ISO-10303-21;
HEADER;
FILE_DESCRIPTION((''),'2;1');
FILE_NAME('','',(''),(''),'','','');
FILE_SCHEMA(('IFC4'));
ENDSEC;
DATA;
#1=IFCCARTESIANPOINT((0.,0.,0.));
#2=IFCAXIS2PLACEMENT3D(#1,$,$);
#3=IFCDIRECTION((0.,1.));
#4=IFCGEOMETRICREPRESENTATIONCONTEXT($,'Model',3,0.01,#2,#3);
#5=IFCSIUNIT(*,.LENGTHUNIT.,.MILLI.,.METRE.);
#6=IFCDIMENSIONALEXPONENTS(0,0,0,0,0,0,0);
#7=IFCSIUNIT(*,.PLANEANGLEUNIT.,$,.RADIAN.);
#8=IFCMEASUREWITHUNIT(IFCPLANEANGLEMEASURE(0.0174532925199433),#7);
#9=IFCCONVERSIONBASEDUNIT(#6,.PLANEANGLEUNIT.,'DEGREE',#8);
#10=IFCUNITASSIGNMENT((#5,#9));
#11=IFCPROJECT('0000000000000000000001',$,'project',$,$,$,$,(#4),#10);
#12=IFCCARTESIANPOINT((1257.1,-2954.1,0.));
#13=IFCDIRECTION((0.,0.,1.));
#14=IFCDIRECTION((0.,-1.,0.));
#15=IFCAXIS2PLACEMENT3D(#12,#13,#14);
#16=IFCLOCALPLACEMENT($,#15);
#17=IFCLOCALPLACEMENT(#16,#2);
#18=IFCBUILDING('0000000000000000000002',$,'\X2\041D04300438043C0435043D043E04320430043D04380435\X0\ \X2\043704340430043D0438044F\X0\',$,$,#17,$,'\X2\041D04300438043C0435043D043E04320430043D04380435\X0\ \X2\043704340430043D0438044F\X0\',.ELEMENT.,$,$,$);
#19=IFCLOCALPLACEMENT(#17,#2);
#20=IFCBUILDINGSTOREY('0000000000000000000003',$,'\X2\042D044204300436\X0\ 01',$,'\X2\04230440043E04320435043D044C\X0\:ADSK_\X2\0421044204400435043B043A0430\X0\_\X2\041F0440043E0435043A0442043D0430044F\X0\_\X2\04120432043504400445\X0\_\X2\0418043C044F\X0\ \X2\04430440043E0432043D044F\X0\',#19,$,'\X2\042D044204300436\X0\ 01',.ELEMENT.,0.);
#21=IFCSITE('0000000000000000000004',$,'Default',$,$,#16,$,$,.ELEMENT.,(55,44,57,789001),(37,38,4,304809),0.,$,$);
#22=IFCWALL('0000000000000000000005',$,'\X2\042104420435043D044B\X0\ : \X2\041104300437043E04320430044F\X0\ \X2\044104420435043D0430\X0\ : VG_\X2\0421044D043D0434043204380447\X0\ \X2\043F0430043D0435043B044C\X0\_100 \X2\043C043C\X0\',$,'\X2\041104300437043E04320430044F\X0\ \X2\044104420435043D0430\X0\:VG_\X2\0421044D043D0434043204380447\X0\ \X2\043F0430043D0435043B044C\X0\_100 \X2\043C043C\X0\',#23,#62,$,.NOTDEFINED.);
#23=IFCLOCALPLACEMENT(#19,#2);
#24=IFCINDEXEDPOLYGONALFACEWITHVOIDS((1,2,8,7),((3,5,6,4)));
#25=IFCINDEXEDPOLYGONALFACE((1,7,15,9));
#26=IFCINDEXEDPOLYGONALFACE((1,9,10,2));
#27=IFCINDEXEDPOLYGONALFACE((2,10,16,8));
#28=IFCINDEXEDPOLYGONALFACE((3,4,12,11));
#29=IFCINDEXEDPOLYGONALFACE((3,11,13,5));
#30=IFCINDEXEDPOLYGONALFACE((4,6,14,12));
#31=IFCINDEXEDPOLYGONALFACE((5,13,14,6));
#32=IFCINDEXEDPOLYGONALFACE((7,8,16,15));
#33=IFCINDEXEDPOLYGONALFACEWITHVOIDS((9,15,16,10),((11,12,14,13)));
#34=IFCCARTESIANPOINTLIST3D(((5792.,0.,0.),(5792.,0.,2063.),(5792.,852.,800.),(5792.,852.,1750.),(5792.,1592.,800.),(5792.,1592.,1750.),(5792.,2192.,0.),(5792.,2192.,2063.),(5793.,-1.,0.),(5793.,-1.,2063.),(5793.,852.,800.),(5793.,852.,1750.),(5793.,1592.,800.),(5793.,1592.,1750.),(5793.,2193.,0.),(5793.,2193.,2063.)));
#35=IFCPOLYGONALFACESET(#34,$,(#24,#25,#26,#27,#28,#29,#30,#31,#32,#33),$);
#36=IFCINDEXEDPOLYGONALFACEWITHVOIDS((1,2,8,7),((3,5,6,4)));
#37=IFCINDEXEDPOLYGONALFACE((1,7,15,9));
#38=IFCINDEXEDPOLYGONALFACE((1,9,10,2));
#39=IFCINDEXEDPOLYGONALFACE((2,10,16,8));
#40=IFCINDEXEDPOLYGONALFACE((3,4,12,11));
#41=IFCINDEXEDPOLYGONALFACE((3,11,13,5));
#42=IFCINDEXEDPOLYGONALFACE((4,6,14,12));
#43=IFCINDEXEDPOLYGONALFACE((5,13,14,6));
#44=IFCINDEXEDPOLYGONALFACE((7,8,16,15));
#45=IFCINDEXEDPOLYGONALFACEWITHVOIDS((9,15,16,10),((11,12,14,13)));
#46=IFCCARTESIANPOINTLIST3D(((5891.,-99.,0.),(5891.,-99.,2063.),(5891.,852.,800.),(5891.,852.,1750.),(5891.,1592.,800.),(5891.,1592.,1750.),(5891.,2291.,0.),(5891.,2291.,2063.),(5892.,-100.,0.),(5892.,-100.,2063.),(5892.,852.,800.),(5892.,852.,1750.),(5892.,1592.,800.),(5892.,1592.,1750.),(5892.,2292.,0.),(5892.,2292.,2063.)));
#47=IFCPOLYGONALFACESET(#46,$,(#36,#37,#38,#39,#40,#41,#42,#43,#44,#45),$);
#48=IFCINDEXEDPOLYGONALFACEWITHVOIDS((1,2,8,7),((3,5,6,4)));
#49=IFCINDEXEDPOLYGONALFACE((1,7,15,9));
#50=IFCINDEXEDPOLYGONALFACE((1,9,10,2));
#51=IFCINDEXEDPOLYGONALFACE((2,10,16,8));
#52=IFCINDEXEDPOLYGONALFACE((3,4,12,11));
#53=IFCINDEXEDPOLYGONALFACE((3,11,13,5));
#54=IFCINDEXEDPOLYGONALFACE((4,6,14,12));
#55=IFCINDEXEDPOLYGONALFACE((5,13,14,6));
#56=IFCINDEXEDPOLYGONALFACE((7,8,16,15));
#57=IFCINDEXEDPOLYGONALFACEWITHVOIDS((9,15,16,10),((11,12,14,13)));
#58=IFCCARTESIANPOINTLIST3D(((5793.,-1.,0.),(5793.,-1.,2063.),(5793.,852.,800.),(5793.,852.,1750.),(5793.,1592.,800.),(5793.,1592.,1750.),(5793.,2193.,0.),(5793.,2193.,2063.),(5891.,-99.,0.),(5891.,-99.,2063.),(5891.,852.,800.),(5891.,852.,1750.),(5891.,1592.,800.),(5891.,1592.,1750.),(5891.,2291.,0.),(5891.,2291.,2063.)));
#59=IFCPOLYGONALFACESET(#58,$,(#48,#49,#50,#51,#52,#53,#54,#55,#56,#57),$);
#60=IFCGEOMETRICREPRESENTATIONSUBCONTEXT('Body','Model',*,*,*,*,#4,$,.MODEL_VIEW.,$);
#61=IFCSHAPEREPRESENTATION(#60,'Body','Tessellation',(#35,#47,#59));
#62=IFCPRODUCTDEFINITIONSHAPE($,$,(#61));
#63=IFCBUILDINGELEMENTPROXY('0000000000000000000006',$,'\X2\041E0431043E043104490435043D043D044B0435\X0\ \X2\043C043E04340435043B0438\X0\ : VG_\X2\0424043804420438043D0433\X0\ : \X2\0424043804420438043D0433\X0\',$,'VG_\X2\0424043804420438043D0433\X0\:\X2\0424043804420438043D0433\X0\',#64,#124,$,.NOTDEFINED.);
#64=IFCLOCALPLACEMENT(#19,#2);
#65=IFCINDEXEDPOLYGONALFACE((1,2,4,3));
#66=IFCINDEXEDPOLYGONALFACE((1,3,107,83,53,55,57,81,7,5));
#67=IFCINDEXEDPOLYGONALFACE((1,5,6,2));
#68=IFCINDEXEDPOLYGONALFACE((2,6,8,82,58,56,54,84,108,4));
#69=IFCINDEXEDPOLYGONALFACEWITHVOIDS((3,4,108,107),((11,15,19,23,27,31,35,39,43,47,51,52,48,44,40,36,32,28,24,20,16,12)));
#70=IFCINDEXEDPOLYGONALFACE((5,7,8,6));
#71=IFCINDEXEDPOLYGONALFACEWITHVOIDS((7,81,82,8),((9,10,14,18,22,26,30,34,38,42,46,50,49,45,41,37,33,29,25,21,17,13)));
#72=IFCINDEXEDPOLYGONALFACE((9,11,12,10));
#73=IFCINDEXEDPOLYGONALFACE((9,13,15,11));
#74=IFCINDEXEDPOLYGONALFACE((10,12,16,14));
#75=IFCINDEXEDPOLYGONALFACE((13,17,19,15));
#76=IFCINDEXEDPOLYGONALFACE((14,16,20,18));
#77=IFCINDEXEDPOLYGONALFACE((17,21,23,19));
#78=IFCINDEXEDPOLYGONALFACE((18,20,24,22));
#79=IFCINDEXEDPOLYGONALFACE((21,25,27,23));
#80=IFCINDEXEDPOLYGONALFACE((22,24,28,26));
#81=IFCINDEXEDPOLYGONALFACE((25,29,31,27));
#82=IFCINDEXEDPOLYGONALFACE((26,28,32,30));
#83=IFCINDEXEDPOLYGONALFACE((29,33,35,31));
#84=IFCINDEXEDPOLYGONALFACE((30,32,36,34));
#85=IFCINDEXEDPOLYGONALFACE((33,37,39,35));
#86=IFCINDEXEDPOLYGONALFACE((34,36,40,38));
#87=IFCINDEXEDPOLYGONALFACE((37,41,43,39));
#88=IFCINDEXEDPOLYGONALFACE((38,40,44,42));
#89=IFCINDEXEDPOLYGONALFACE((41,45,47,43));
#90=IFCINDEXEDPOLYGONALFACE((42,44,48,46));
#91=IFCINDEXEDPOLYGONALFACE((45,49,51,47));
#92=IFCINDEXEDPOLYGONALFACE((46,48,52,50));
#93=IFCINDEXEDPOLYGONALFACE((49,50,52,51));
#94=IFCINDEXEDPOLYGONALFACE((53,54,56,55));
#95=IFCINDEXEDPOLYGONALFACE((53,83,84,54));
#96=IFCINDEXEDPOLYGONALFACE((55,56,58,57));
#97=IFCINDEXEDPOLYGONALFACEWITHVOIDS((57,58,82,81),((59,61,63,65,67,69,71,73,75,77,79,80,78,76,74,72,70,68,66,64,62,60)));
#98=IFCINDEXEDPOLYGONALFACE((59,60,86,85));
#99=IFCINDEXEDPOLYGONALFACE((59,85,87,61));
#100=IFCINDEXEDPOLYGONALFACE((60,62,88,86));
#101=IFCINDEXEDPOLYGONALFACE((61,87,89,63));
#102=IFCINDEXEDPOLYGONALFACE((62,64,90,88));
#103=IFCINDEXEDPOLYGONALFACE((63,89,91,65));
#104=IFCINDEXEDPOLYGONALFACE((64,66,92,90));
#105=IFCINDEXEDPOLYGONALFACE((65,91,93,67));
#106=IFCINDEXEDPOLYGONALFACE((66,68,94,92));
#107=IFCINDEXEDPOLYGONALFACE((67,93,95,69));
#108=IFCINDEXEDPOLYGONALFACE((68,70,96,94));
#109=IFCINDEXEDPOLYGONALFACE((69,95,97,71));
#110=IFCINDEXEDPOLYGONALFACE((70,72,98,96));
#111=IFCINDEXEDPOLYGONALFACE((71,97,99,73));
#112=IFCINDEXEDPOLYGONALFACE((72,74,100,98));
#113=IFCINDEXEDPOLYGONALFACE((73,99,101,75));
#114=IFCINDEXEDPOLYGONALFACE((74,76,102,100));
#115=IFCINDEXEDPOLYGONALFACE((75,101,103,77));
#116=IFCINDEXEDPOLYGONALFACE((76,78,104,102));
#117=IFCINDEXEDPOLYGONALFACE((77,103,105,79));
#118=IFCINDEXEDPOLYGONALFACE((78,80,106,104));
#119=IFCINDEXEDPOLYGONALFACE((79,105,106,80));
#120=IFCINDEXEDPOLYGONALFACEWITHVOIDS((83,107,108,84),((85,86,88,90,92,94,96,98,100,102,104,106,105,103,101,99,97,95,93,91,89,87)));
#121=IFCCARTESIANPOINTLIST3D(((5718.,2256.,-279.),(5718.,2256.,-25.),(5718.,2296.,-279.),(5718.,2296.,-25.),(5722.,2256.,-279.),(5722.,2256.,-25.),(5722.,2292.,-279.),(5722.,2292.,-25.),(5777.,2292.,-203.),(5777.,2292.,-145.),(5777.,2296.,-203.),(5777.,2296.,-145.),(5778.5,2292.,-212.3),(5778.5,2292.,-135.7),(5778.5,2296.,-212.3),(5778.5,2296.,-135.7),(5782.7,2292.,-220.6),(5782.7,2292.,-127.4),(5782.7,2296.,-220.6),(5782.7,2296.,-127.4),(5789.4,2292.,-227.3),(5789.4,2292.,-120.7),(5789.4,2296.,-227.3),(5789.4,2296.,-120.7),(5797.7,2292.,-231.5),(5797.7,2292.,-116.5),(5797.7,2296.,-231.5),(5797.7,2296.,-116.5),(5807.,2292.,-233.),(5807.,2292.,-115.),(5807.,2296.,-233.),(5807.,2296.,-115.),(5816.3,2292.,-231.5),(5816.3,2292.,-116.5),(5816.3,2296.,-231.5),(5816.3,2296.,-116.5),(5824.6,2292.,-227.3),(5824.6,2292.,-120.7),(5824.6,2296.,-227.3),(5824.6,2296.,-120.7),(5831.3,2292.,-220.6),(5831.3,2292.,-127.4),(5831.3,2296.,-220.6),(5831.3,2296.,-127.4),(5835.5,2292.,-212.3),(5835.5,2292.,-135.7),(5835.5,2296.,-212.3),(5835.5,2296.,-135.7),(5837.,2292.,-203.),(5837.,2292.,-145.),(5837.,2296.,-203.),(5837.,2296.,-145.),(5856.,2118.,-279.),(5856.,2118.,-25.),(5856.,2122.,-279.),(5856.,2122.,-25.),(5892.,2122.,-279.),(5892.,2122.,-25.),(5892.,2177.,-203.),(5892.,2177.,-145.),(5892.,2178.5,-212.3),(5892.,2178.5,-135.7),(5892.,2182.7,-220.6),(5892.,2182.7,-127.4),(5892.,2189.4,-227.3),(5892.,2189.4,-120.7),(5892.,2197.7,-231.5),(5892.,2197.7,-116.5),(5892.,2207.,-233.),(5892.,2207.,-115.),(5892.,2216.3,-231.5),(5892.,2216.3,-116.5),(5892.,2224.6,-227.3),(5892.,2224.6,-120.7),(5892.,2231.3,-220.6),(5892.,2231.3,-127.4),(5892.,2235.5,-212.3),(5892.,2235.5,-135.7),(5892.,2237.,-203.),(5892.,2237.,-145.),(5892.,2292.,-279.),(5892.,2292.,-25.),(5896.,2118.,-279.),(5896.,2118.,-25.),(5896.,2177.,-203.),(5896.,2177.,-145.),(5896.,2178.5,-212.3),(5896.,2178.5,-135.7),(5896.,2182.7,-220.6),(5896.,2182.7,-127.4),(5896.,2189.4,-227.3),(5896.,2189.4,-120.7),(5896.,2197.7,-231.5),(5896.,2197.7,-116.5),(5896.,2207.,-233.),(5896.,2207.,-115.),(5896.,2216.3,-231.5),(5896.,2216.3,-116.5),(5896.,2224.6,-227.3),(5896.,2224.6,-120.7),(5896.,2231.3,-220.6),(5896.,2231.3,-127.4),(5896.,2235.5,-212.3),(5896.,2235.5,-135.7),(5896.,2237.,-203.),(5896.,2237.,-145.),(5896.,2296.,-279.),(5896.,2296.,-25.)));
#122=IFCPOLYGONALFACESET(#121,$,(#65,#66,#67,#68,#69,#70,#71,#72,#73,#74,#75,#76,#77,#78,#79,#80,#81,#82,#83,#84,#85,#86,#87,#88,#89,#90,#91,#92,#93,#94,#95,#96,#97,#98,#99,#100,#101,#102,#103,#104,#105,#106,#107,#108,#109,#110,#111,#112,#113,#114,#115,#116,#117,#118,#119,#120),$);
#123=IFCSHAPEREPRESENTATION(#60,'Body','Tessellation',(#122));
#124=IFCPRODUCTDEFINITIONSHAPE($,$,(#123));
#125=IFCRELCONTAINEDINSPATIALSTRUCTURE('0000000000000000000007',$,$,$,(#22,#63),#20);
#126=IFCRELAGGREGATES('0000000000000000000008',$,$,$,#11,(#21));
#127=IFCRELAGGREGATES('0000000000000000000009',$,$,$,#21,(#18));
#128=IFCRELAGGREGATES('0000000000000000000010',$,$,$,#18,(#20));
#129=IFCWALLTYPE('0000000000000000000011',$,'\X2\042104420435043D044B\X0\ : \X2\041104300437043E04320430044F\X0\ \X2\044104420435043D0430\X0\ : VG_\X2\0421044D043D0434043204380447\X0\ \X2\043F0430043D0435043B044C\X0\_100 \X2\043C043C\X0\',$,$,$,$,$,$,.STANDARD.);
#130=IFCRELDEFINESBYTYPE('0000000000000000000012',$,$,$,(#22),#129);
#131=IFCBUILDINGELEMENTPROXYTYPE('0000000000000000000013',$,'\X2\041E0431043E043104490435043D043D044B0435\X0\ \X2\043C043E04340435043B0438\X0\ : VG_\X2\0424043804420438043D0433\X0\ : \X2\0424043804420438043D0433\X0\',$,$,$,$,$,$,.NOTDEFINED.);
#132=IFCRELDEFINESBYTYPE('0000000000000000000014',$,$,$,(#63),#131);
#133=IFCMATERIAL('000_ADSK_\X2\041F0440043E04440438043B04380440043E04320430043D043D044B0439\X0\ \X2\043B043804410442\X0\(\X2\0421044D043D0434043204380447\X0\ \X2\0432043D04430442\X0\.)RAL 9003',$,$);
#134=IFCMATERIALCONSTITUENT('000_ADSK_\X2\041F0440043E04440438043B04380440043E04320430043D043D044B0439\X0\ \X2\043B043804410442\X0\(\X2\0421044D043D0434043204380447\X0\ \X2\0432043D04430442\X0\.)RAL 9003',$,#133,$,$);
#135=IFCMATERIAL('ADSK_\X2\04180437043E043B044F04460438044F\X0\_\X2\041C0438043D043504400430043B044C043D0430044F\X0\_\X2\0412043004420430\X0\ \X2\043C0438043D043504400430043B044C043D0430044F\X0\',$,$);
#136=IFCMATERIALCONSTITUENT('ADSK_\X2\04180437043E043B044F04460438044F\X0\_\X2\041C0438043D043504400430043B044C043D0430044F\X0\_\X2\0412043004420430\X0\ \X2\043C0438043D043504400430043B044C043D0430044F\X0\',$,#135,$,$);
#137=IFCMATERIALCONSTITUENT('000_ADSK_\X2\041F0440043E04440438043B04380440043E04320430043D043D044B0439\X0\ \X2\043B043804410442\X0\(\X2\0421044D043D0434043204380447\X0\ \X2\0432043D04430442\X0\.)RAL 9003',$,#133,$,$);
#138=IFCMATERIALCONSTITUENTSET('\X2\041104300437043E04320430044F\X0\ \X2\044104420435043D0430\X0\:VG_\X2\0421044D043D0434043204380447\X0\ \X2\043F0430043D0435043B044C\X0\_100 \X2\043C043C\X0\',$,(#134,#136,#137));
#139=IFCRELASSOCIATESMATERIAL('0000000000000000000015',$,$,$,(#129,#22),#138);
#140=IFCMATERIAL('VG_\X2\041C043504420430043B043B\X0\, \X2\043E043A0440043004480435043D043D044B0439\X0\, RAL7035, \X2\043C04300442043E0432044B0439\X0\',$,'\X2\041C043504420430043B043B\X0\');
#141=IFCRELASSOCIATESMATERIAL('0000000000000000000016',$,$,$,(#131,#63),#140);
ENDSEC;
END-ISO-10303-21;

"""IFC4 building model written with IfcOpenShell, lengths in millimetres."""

from ifc_helpers import new_model, entity, si_unit, converted_unit, direction, frame, origin, place, context, subcontext, project, spatial, indexed_curve, outline, extrude, source, transform, mapped, material, constituent, constituent_set, type_object, type_shapes, element, save


model = new_model("IFC4")

# Units and contexts
model_context = context("Model", 3, precision=0.01, world=origin(), true_north=direction((0.0, 1.0)))
body_context = subcontext(model_context, "Body", "Model", "MODEL_VIEW")
ifc_project = project(units=[si_unit("LENGTHUNIT", "METRE", prefix="MILLI"), converted_unit("PLANEANGLEUNIT", "DEGREE", entity("IfcPlaneAngleMeasure", 0.0174532925199433), si_unit("PLANEANGLEUNIT", "RADIAN"), dimensions=[0, 0, 0, 0, 0, 0, 0])], contexts=[model_context])

# Site, building, storey
site_placement = place(None, frame((1257.1, -2954.1, 0.0), z_axis=(0.0, 0.0, 1.0), x_axis=(0.0, -1.0, 0.0)))
site = spatial("IfcSite", under=ifc_project, at=site_placement, Name="Default", CompositionType="ELEMENT", RefLatitude=(55, 44, 57, 789001), RefLongitude=(37, 38, 4, 304809), RefElevation=0.0)
building_placement = place(site_placement, origin())
building = spatial("IfcBuilding", under=site, at=building_placement, Name="Наименование здания", LongName="Наименование здания", CompositionType="ELEMENT")
storey_placement = place(building_placement, origin())
storey = spatial("IfcBuildingStorey", under=building, at=storey_placement, Name="Этаж 01", ObjectType="Уровень:ADSK_Стрелка_Проектная_Вверх_Имя уровня", LongName="Этаж 01", CompositionType="ELEMENT", Elevation=0.0)

# Wall, openings
ifc_material_1 = material(Name="000_ADSK_Профилированный лист(Сэндвич внут.)RAL 9003")
ifc_constituent_1 = constituent(ifc_material_1, Name="000_ADSK_Профилированный лист(Сэндвич внут.)RAL 9003")
ifc_material_2 = material(Name="ADSK_Изоляция_Минеральная_Вата минеральная")
ifc_constituent_2 = constituent(ifc_material_2, Name="ADSK_Изоляция_Минеральная_Вата минеральная")
ifc_constituent_3 = constituent(ifc_material_1, Name="000_ADSK_Профилированный лист(Сэндвич внут.)RAL 9003")
ifc_constituent_set_1 = constituent_set(constituents=[ifc_constituent_1, ifc_constituent_2, ifc_constituent_3], Name="Базовая стена:VG_Сэндвич панель_100 мм")
wall_type_1 = type_object("IfcWallType", Name="Стены : Базовая стена : VG_Сэндвич панель_100 мм", PredefinedType="STANDARD", material=ifc_constituent_set_1)
wall_1_placement = place(storey_placement, frame((5842.0, -100.0, 0.0), z_axis=(0.0, 0.0, 1.0), x_axis=(0.0, 1.0, 0.0)))
wall_1 = element("IfcWall", 1, at=wall_1_placement, inside=storey, type_object=wall_type_1, material=ifc_constituent_set_1, Name="Стены : Базовая стена : VG_Сэндвич панель_100 мм", ObjectType="Базовая стена:VG_Сэндвич панель_100 мм", PredefinedType="NOTDEFINED", context=body_context, shape_type="SweptSolid", body=[
    extrude(outline(indexed_curve([(774.6, -775.3), (776.0, -775.3), (-775.3, 776.0), (-775.3, 774.6), (774.6, -775.3)], self_intersect=False)), frame((1196.0, 49.5, 0.0), z_axis=(0.0, 0.0, 1.0), x_axis=(-0.707107, -0.707107, 0.0)), (0.0, 0.0, 1.0), 2063.0),
    extrude(outline(indexed_curve([(-846.1, -845.3), (-844.6, -845.3), (845.3, 844.6), (845.3, 846.1), (-846.1, -845.3)], self_intersect=False)), frame((1196.0, -49.5, 0.0), z_axis=(0.0, 0.0, 1.0), x_axis=(-0.707107, 0.707107, 0.0)), (0.0, 0.0, 1.0), 2063.0),
    extrude(outline(indexed_curve([(-1195.0, -49.0), (1195.0, -49.0), (1097.0, 49.0), (-1097.0, 49.0), (-1195.0, -49.0)], self_intersect=False)), frame((1196.0, 0.0, 0.0)), (0.0, 0.0, 1.0), 2063.0),
])
opening_1_placement = place(storey_placement, frame((5842.0, -100.0, 0.0), z_axis=(0.0, 0.0, 1.0), x_axis=(0.0, 1.0, 0.0)))
element("IfcOpeningElement", 2, at=opening_1_placement, cuts=wall_1, PredefinedType="OPENING", context=body_context, shape_type="SweptSolid", body=[
    extrude(outline(indexed_curve([(-370.0, -475.0), (370.0, -475.0), (370.0, 475.0), (-370.0, 475.0), (-370.0, -475.0)], self_intersect=False)), frame((1322.0, -49.0, 1275.0), z_axis=(0.0, 1.0, 0.0), x_axis=(1.0, 0.0, 0.0)), (0.0, 0.0, 1.0), 98.0),
])
opening_2_placement = place(storey_placement, frame((5842.0, -100.0, 0.0), z_axis=(0.0, 0.0, 1.0), x_axis=(0.0, 1.0, 0.0)))
element("IfcOpeningElement", 3, at=opening_2_placement, cuts=wall_1, PredefinedType="OPENING", context=body_context, shape_type="SweptSolid", body=[
    extrude(outline(indexed_curve([(-370.0, -475.0), (370.0, -475.0), (370.0, 475.0), (-370.0, 475.0), (-370.0, -475.0)], self_intersect=False)), frame((1322.0, -49.0, 1275.0), z_axis=(0.0, -1.0, 0.0), x_axis=(-1.0, 0.0, 0.0)), (0.0, 0.0, 1.0), 1.0),
])
opening_3_placement = place(storey_placement, frame((5842.0, -100.0, 0.0), z_axis=(0.0, 0.0, 1.0), x_axis=(0.0, 1.0, 0.0)))
element("IfcOpeningElement", 4, at=opening_3_placement, cuts=wall_1, PredefinedType="OPENING", context=body_context, shape_type="SweptSolid", body=[
    extrude(outline(indexed_curve([(-370.0, -475.0), (370.0, -475.0), (370.0, 475.0), (-370.0, 475.0), (-370.0, -475.0)], self_intersect=False)), frame((1322.0, 50.0, 1275.0), z_axis=(0.0, -1.0, 0.0), x_axis=(-1.0, 0.0, 0.0)), (0.0, 0.0, 1.0), 1.0),
])
opening_4_placement = place(wall_1_placement, frame((100.0, 5842.0, 0.0), z_axis=(0.0, 0.0, 1.0), x_axis=(0.0, -1.0, 0.0)))
element("IfcOpeningElement", 5, at=opening_4_placement, cuts=wall_1, PredefinedType="OPENING", context=body_context, shape_type="SweptSolid", body=[
    extrude(outline(indexed_curve([(-475.0, -370.0), (475.0, -370.0), (475.0, 370.0), (-475.0, 370.0), (-475.0, -370.0)], self_intersect=False)), frame((6392.0, 1222.0, 1275.0), z_axis=(-1.0, 0.0, 0.0), x_axis=(0.0, 0.0, -1.0)), (0.0, 0.0, 1.0), 1500.0),
])

# Building element proxy, openings
ifc_material_3 = material(Name="VG_Металл, окрашенный, RAL7035, матовый", Category="Металл")
building_element_proxy_type_1 = type_object("IfcBuildingElementProxyType", Name="Обобщенные модели : VG_Фитинг : Фитинг", PredefinedType="NOTDEFINED", material=ifc_material_3)
shared_shape_1 = source(origin(), body_context, "Body", "SweptSolid", [
    extrude(outline(indexed_curve([(-79.2, -79.2), (98.8, -79.2), (98.8, -39.2), (94.8, -39.2), (94.8, -75.2), (-75.2, -75.2), (-75.2, 94.8), (-39.2, 94.8), (-39.2, 98.8), (-79.2, 98.8), (-79.2, -79.2)], self_intersect=False)), frame((-9.8, -9.8, -279.0)), (0.0, 0.0, 1.0), 254.0),
])
type_shapes(building_element_proxy_type_1, [shared_shape_1])
proxy_1_placement = place(storey_placement, frame((5807.0, 2207.0, 0.0), z_axis=(0.0, 0.0, 1.0), x_axis=(-1.0, 0.0, 0.0)))
proxy_1 = element("IfcBuildingElementProxy", 6, at=proxy_1_placement, inside=storey, type_object=building_element_proxy_type_1, material=ifc_material_3, Name="Обобщенные модели : VG_Фитинг : Фитинг", ObjectType="VG_Фитинг:Фитинг", PredefinedType="NOTDEFINED", context=body_context, shape_type="MappedRepresentation", body=[
    mapped(shared_shape_1, transform((0.0, 0.0, 0.0), scale=1.0)),
])
opening_5_placement = place(storey_placement, frame((5807.0, 2207.0, 0.0)))
element("IfcOpeningElement", 7, at=opening_5_placement, cuts=proxy_1, PredefinedType="OPENING", context=body_context, shape_type="SweptSolid", body=[
    extrude(outline(indexed_curve([(30.0, 29.0), (28.5, 38.3), (24.3, 46.6), (17.6, 53.3), (9.3, 57.5), (0.0, 59.0), (-9.3, 57.5), (-17.6, 53.3), (-24.3, 46.6), (-28.5, 38.3), (-30.0, 29.0), (-30.0, -29.0), (-28.5, -38.3), (-24.3, -46.6), (-17.6, -53.3), (-9.3, -57.5), (0.0, -59.0), (9.3, -57.5), (17.6, -53.3), (24.3, -46.6), (28.5, -38.3), (30.0, -29.0), (30.0, 29.0)], self_intersect=False)), frame((0.0, 85.0, -174.0), z_axis=(0.0, 1.0, 0.0), x_axis=(-1.0, 0.0, 0.0)), (0.0, 0.0, 1.0), 4.0),
])
opening_6_placement = place(storey_placement, frame((5807.0, 2207.0, 0.0)))
element("IfcOpeningElement", 8, at=opening_6_placement, cuts=proxy_1, PredefinedType="OPENING", context=body_context, shape_type="SweptSolid", body=[
    extrude(outline(indexed_curve([(-30.0, -29.0), (-28.5, -38.3), (-24.3, -46.6), (-17.6, -53.3), (-9.3, -57.5), (0.0, -59.0), (9.3, -57.5), (17.6, -53.3), (24.3, -46.6), (28.5, -38.3), (30.0, -29.0), (30.0, 29.0), (28.5, 38.3), (24.3, 46.6), (17.6, 53.3), (9.3, 57.5), (0.0, 59.0), (-9.3, 57.5), (-17.6, 53.3), (-24.3, 46.6), (-28.5, 38.3), (-30.0, 29.0), (-30.0, -29.0)], self_intersect=False)), frame((89.0, 0.0, -174.0), z_axis=(-1.0, 0.0, 0.0), x_axis=(0.0, 1.0, 0.0)), (0.0, 0.0, 1.0), 4.0),
])

save(model, "model.ifc")
